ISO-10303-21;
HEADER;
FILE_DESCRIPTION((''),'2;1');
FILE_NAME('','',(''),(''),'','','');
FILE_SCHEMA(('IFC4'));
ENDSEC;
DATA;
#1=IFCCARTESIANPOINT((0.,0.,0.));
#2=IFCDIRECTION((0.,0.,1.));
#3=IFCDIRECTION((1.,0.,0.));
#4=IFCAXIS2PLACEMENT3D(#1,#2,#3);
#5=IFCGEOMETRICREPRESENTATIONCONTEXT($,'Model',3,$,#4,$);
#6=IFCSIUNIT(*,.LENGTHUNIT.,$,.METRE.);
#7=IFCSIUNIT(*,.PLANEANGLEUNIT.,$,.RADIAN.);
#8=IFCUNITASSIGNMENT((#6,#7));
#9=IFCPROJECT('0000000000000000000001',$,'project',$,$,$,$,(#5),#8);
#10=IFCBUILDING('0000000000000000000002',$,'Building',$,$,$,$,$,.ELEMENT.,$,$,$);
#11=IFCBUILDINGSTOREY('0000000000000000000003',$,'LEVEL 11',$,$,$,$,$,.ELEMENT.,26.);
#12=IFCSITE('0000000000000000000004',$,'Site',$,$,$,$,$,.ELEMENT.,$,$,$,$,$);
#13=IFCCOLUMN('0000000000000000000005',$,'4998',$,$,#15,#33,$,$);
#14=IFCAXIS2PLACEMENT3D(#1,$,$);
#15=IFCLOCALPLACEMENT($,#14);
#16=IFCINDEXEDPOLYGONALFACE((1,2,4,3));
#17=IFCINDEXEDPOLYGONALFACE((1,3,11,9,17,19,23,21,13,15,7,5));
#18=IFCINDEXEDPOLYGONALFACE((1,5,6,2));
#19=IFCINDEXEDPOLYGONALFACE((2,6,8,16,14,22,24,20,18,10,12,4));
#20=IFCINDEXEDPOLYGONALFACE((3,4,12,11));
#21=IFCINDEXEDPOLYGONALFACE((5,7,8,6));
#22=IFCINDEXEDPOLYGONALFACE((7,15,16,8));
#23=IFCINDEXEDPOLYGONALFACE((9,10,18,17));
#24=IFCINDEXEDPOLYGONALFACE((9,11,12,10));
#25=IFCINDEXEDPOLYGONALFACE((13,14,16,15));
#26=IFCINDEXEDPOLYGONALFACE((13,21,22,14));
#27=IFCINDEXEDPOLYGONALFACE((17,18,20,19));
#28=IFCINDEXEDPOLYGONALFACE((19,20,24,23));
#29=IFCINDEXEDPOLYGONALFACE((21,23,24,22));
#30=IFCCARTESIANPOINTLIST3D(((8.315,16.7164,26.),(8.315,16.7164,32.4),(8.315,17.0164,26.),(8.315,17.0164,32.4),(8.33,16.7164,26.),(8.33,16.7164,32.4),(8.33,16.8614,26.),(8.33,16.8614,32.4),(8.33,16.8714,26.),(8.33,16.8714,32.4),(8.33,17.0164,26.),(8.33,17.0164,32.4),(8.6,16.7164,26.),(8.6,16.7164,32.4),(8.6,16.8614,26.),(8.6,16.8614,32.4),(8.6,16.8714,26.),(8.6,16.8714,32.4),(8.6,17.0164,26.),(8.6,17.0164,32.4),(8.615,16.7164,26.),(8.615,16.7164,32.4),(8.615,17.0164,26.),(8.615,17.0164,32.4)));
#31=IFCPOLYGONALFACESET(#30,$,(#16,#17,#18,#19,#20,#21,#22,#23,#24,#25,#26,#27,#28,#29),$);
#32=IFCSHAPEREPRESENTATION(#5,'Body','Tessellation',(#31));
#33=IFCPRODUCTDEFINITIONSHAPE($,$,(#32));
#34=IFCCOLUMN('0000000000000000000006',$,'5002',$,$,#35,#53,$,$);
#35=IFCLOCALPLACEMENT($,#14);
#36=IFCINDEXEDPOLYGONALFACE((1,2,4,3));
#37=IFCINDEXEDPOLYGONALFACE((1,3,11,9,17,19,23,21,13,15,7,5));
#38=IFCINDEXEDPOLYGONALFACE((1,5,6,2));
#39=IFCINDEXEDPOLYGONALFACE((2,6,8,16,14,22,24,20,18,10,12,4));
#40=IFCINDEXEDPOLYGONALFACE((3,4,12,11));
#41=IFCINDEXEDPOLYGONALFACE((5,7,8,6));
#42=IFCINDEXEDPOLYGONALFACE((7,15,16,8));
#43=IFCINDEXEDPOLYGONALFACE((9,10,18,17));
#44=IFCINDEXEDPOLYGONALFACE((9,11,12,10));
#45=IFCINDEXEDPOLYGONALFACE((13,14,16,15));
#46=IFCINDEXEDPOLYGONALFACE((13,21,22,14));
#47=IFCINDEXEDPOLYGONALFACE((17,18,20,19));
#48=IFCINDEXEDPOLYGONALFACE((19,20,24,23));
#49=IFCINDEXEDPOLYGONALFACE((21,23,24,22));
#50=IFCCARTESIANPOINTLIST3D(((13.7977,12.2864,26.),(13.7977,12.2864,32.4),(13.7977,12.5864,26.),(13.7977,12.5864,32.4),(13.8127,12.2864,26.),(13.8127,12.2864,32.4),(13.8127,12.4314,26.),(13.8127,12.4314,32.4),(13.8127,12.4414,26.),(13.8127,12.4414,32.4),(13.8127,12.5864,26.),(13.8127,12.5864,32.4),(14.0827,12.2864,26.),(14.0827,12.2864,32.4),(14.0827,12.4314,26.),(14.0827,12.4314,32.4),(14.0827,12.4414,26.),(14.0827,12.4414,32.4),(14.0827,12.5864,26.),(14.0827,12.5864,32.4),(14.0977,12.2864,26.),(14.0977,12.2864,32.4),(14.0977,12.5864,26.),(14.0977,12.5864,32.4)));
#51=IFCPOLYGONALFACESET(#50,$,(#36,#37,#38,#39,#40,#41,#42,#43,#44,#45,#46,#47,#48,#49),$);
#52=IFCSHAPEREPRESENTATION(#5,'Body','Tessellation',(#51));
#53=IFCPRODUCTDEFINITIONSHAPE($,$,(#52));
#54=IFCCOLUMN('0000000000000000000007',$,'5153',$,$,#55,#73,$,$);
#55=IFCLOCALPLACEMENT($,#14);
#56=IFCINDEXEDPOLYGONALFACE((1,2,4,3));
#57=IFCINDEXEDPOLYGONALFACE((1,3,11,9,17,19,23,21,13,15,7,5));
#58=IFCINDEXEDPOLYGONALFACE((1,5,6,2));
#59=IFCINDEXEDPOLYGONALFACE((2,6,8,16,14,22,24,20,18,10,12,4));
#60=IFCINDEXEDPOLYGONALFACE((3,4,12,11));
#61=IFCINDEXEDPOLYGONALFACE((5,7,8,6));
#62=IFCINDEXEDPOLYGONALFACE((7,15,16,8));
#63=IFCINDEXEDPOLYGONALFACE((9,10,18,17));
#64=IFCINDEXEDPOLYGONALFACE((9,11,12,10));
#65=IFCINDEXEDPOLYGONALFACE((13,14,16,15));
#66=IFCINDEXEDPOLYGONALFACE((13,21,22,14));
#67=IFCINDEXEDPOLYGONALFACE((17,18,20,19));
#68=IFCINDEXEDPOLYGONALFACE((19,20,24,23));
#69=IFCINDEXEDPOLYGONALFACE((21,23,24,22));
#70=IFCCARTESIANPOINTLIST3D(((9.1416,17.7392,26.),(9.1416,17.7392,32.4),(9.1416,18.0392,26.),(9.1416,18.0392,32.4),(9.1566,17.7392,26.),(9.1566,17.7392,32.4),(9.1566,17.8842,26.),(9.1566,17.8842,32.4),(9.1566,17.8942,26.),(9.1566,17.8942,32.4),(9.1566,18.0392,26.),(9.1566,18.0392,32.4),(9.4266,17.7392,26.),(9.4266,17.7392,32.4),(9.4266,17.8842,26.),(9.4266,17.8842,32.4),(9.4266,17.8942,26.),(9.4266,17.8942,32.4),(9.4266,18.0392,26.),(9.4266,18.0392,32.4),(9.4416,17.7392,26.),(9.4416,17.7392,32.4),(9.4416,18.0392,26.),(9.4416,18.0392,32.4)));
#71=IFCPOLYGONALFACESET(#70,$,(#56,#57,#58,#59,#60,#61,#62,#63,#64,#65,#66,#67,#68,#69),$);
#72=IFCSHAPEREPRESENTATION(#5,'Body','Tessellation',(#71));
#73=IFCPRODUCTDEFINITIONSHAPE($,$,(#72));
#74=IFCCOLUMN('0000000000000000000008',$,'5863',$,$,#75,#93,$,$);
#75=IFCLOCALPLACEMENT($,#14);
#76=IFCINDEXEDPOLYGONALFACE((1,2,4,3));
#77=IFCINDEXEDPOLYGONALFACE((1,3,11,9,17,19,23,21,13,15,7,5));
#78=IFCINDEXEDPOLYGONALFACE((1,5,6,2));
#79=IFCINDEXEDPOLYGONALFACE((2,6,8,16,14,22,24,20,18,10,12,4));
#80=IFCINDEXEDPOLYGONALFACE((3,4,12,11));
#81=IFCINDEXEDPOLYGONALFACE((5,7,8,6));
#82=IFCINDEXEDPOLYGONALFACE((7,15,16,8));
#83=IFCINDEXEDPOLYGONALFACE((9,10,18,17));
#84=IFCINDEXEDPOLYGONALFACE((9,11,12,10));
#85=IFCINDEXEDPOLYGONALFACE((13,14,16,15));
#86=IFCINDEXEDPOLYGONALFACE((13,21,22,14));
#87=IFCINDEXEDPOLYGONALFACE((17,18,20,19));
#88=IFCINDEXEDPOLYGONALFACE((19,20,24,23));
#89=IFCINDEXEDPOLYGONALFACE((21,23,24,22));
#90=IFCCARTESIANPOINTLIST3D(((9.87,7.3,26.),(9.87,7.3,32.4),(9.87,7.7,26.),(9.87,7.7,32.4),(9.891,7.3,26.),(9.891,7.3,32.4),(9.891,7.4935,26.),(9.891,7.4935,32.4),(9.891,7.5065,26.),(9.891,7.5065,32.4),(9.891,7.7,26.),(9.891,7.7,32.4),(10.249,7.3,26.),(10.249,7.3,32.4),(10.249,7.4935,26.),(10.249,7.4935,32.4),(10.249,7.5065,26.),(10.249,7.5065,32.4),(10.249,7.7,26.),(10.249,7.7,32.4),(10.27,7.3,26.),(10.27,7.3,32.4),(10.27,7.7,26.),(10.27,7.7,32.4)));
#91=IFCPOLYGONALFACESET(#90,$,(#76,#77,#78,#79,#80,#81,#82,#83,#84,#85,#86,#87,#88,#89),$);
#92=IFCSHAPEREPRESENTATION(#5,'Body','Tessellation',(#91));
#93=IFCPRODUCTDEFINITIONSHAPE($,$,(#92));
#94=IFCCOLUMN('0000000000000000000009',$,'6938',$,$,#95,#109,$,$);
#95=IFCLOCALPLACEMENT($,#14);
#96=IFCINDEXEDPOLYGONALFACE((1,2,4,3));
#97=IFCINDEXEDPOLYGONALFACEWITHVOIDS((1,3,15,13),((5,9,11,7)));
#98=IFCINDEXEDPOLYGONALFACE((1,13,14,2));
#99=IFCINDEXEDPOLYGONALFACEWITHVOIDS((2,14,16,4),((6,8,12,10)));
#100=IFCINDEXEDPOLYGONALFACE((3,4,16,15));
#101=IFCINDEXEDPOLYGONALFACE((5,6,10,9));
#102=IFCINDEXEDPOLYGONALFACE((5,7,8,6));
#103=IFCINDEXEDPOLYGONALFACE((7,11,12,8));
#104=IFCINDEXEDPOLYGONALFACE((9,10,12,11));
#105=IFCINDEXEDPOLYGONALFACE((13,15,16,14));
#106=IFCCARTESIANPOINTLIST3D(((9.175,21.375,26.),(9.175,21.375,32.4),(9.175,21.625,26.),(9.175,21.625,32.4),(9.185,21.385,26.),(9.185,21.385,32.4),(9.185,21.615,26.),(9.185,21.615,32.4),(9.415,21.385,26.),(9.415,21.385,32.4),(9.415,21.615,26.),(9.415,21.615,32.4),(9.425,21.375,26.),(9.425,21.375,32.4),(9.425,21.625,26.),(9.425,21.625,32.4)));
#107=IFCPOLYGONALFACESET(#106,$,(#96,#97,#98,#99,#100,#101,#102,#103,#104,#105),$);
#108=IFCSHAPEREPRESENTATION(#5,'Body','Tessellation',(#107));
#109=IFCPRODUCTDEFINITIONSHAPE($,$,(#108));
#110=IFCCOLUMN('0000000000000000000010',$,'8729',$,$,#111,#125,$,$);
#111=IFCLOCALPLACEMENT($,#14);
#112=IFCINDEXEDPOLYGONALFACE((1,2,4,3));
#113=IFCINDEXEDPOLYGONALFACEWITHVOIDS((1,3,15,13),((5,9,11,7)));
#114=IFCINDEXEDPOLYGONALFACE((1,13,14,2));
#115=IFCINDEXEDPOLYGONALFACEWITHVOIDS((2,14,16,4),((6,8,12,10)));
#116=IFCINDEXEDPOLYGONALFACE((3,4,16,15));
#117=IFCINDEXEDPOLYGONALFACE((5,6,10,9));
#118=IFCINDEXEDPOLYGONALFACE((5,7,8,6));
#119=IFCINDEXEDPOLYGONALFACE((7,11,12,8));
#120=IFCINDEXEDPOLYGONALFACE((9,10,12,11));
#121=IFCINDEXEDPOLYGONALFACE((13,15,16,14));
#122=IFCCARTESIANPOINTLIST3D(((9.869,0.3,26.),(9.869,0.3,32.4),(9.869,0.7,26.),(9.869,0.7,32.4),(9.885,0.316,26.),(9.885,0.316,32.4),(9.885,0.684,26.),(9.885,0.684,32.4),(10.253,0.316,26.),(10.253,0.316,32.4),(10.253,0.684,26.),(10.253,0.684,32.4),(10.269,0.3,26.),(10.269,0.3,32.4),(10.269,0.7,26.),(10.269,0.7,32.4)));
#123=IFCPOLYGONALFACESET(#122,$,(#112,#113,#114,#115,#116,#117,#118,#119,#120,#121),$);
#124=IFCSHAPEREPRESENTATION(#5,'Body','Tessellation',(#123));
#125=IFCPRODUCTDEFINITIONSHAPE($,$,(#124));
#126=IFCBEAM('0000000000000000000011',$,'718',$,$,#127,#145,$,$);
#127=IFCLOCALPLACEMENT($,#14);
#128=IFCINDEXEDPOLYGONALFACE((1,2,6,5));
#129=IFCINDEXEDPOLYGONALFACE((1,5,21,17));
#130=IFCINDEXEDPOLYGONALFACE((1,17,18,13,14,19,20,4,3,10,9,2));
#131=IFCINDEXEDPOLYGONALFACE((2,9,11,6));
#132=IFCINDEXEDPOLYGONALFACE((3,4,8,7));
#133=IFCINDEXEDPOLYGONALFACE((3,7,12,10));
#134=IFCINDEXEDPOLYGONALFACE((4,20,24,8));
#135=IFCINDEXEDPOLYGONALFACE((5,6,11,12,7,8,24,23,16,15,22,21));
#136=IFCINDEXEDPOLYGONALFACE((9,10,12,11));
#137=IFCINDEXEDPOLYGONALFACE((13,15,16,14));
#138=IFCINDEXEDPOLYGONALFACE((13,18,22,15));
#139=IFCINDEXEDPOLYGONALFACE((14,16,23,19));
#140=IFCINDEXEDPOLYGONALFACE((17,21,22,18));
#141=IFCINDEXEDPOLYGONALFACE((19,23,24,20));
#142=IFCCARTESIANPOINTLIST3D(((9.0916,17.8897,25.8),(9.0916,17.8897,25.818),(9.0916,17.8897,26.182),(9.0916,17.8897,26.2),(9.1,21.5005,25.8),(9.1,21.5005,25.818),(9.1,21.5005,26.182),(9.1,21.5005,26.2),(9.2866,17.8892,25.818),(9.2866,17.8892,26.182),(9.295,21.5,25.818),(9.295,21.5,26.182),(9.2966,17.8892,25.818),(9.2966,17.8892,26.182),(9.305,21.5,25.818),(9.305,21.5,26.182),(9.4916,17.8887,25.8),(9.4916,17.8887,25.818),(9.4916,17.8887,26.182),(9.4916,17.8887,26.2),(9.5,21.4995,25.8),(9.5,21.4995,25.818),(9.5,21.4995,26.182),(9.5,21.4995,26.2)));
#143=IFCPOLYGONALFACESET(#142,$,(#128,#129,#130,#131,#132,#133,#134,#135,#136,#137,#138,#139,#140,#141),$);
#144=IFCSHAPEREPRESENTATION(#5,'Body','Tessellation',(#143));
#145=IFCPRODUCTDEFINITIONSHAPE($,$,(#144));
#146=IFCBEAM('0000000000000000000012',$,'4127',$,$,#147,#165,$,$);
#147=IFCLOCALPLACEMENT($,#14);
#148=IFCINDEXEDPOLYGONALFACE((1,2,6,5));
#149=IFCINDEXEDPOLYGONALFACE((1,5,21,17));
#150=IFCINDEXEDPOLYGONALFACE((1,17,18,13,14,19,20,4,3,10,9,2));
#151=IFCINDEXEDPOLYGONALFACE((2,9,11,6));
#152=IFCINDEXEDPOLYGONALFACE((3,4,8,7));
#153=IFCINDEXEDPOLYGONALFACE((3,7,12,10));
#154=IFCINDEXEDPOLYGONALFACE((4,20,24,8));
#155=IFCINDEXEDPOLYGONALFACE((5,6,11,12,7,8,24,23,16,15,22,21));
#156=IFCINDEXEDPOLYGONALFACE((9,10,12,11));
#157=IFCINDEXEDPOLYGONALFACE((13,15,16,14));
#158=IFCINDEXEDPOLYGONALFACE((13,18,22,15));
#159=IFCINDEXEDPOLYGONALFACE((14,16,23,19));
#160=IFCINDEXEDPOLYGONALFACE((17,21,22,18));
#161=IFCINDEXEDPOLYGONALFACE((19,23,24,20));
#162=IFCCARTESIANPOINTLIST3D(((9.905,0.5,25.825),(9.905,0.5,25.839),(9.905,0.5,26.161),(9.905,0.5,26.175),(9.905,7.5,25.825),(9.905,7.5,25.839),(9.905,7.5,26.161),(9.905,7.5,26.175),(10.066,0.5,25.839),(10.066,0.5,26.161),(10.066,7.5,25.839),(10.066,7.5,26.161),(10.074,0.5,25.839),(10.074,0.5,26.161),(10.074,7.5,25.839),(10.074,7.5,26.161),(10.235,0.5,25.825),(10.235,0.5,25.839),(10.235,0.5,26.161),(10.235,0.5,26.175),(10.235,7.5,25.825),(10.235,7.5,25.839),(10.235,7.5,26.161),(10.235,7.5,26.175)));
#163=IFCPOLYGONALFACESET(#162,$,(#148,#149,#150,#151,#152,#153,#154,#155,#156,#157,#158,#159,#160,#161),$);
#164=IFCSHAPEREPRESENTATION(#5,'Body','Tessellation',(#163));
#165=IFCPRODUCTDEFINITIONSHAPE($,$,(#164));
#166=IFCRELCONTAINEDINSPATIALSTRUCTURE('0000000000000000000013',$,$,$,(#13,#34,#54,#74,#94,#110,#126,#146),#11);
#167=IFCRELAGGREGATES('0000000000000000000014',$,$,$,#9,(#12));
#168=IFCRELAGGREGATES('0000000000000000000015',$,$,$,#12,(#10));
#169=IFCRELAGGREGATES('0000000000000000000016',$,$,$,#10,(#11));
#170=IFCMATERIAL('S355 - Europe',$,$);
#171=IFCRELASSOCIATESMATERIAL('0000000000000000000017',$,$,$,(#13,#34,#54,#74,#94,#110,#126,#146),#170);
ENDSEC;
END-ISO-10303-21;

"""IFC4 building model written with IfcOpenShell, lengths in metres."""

from ifc_helpers import new_model, si_unit, frame, origin_with_axes, origin_2d_with_axis, place, context, project, spatial, hollow_rectangle, i_section, extrude, material, material_profile, profile_set, profile_usage, element, save


model = new_model("IFC4")

# Units and contexts
model_context = context("Model", 3, world=origin_with_axes())
ifc_project = project(units=[si_unit("LENGTHUNIT", "METRE"), si_unit("PLANEANGLEUNIT", "RADIAN")], contexts=[model_context])

# Site, building, storey
site = spatial("IfcSite", under=ifc_project, Name="Site", CompositionType="ELEMENT")
building = spatial("IfcBuilding", under=site, Name="Building", CompositionType="ELEMENT")
storey = spatial("IfcBuildingStorey", under=building, Name="LEVEL 11", CompositionType="ELEMENT", Elevation=26.0)

# Columns
ifc_material = material(Name="S355 - Europe")
ifc_material_profile_1 = material_profile(ifc_material, i_section(OverallWidth=0.3, OverallDepth=0.3, WebThickness=0.01, FlangeThickness=0.015, at=origin_2d_with_axis()))
ifc_profile_set_1 = profile_set([ifc_material_profile_1])
ifc_profile_usage_1 = profile_usage(ifc_profile_set_1, cardinal=10)
column_1_placement = place(None, frame((8.465, 16.8664, 26.0), z_axis=(0.0, 0.0, 1.0), x_axis=(0.0, -1.0, 0.0)))
element("IfcColumn", 1, at=column_1_placement, inside=storey, material=ifc_profile_usage_1, Name="4998", context=model_context, shape_type="SweptSolid", body=[
    extrude(i_section(OverallWidth=0.3, OverallDepth=0.3, WebThickness=0.01, FlangeThickness=0.015, at=origin_2d_with_axis()), origin_with_axes(), (0.0, 0.0, 1.0), 6.4),
])
ifc_material_profile_2 = material_profile(ifc_material, i_section(OverallWidth=0.3, OverallDepth=0.3, WebThickness=0.01, FlangeThickness=0.015, at=origin_2d_with_axis()))
ifc_profile_set_2 = profile_set([ifc_material_profile_2])
ifc_profile_usage_2 = profile_usage(ifc_profile_set_2, cardinal=10)
column_2_placement = place(None, frame((13.9477, 12.4364, 26.0), z_axis=(0.0, 0.0, 1.0), x_axis=(0.0, -1.0, 0.0)))
element("IfcColumn", 2, at=column_2_placement, inside=storey, material=ifc_profile_usage_2, Name="5002", context=model_context, shape_type="SweptSolid", body=[
    extrude(i_section(OverallWidth=0.3, OverallDepth=0.3, WebThickness=0.01, FlangeThickness=0.015, at=origin_2d_with_axis()), origin_with_axes(), (0.0, 0.0, 1.0), 6.4),
])
ifc_material_profile_3 = material_profile(ifc_material, i_section(OverallWidth=0.3, OverallDepth=0.3, WebThickness=0.01, FlangeThickness=0.015, at=origin_2d_with_axis()))
ifc_profile_set_3 = profile_set([ifc_material_profile_3])
ifc_profile_usage_3 = profile_usage(ifc_profile_set_3, cardinal=10)
column_3_placement = place(None, frame((9.2916, 17.8892, 26.0), z_axis=(0.0, 0.0, 1.0), x_axis=(0.0, -1.0, 0.0)))
element("IfcColumn", 3, at=column_3_placement, inside=storey, material=ifc_profile_usage_3, Name="5153", context=model_context, shape_type="SweptSolid", body=[
    extrude(i_section(OverallWidth=0.3, OverallDepth=0.3, WebThickness=0.01, FlangeThickness=0.015, at=origin_2d_with_axis()), origin_with_axes(), (0.0, 0.0, 1.0), 6.4),
])
ifc_material_profile_4 = material_profile(ifc_material, i_section(OverallWidth=0.4, OverallDepth=0.4, WebThickness=0.013, FlangeThickness=0.021, at=origin_2d_with_axis()))
ifc_profile_set_4 = profile_set([ifc_material_profile_4])
ifc_profile_usage_4 = profile_usage(ifc_profile_set_4, cardinal=10)
column_4_placement = place(None, frame((10.07, 7.5, 26.0), z_axis=(0.0, 0.0, 1.0), x_axis=(0.0, -1.0, 0.0)))
element("IfcColumn", 4, at=column_4_placement, inside=storey, material=ifc_profile_usage_4, Name="5863", context=model_context, shape_type="SweptSolid", body=[
    extrude(i_section(OverallWidth=0.4, OverallDepth=0.4, WebThickness=0.013, FlangeThickness=0.021, at=origin_2d_with_axis()), origin_with_axes(), (0.0, 0.0, 1.0), 6.4),
])
ifc_material_profile_5 = material_profile(ifc_material, hollow_rectangle(XDim=0.25, YDim=0.25, WallThickness=0.01, at=origin_2d_with_axis()))
ifc_profile_set_5 = profile_set([ifc_material_profile_5])
ifc_profile_usage_5 = profile_usage(ifc_profile_set_5, cardinal=10)
column_5_placement = place(None, frame((9.3, 21.5, 26.0), z_axis=(0.0, 0.0, 1.0), x_axis=(0.0, -1.0, 0.0)))
element("IfcColumn", 5, at=column_5_placement, inside=storey, material=ifc_profile_usage_5, Name="6938", context=model_context, shape_type="SweptSolid", body=[
    extrude(hollow_rectangle(XDim=0.25, YDim=0.25, WallThickness=0.01, at=origin_2d_with_axis()), origin_with_axes(), (0.0, 0.0, 1.0), 6.4),
])
ifc_material_profile_6 = material_profile(ifc_material, hollow_rectangle(XDim=0.4, YDim=0.4, WallThickness=0.016, at=origin_2d_with_axis()))
ifc_profile_set_6 = profile_set([ifc_material_profile_6])
ifc_profile_usage_6 = profile_usage(ifc_profile_set_6, cardinal=10)
column_6_placement = place(None, frame((10.069, 0.5, 26.0), z_axis=(0.0, 0.0, 1.0), x_axis=(0.0, -1.0, 0.0)))
element("IfcColumn", 6, at=column_6_placement, inside=storey, material=ifc_profile_usage_6, Name="8729", context=model_context, shape_type="SweptSolid", body=[
    extrude(hollow_rectangle(XDim=0.4, YDim=0.4, WallThickness=0.016, at=origin_2d_with_axis()), origin_with_axes(), (0.0, 0.0, 1.0), 6.4),
])

# Beams
ifc_material_profile_7 = material_profile(ifc_material, i_section(OverallWidth=0.4, OverallDepth=0.4, WebThickness=0.01, FlangeThickness=0.018, at=origin_2d_with_axis()))
ifc_profile_set_7 = profile_set([ifc_material_profile_7])
ifc_profile_usage_7 = profile_usage(ifc_profile_set_7, cardinal=10)
beam_1_placement = place(None, frame((9.3, 21.5, 26.0), z_axis=(-0.002337, -0.999997, 0.0), x_axis=(0.999997, -0.002337, 0.0)))
element("IfcBeam", 7, at=beam_1_placement, inside=storey, material=ifc_profile_usage_7, Name="718", context=model_context, shape_type="SweptSolid", body=[
    extrude(i_section(OverallWidth=0.4, OverallDepth=0.4, WebThickness=0.01, FlangeThickness=0.018, at=origin_2d_with_axis()), origin_with_axes(), (0.0, 0.0, 1.0), 3.6108),
])
ifc_material_profile_8 = material_profile(ifc_material, i_section(OverallWidth=0.33, OverallDepth=0.35, WebThickness=0.008, FlangeThickness=0.014, at=origin_2d_with_axis()))
ifc_profile_set_8 = profile_set([ifc_material_profile_8])
ifc_profile_usage_8 = profile_usage(ifc_profile_set_8, cardinal=10)
beam_2_placement = place(None, frame((10.07, 7.5, 26.0), z_axis=(0.0, -1.0, 0.0), x_axis=(1.0, 0.0, 0.0)))
element("IfcBeam", 8, at=beam_2_placement, inside=storey, material=ifc_profile_usage_8, Name="4127", context=model_context, shape_type="SweptSolid", body=[
    extrude(i_section(OverallWidth=0.33, OverallDepth=0.35, WebThickness=0.008, FlangeThickness=0.014, at=origin_2d_with_axis()), origin_with_axes(), (0.0, 0.0, 1.0), 7.0),
])

save(model, "model.ifc")
